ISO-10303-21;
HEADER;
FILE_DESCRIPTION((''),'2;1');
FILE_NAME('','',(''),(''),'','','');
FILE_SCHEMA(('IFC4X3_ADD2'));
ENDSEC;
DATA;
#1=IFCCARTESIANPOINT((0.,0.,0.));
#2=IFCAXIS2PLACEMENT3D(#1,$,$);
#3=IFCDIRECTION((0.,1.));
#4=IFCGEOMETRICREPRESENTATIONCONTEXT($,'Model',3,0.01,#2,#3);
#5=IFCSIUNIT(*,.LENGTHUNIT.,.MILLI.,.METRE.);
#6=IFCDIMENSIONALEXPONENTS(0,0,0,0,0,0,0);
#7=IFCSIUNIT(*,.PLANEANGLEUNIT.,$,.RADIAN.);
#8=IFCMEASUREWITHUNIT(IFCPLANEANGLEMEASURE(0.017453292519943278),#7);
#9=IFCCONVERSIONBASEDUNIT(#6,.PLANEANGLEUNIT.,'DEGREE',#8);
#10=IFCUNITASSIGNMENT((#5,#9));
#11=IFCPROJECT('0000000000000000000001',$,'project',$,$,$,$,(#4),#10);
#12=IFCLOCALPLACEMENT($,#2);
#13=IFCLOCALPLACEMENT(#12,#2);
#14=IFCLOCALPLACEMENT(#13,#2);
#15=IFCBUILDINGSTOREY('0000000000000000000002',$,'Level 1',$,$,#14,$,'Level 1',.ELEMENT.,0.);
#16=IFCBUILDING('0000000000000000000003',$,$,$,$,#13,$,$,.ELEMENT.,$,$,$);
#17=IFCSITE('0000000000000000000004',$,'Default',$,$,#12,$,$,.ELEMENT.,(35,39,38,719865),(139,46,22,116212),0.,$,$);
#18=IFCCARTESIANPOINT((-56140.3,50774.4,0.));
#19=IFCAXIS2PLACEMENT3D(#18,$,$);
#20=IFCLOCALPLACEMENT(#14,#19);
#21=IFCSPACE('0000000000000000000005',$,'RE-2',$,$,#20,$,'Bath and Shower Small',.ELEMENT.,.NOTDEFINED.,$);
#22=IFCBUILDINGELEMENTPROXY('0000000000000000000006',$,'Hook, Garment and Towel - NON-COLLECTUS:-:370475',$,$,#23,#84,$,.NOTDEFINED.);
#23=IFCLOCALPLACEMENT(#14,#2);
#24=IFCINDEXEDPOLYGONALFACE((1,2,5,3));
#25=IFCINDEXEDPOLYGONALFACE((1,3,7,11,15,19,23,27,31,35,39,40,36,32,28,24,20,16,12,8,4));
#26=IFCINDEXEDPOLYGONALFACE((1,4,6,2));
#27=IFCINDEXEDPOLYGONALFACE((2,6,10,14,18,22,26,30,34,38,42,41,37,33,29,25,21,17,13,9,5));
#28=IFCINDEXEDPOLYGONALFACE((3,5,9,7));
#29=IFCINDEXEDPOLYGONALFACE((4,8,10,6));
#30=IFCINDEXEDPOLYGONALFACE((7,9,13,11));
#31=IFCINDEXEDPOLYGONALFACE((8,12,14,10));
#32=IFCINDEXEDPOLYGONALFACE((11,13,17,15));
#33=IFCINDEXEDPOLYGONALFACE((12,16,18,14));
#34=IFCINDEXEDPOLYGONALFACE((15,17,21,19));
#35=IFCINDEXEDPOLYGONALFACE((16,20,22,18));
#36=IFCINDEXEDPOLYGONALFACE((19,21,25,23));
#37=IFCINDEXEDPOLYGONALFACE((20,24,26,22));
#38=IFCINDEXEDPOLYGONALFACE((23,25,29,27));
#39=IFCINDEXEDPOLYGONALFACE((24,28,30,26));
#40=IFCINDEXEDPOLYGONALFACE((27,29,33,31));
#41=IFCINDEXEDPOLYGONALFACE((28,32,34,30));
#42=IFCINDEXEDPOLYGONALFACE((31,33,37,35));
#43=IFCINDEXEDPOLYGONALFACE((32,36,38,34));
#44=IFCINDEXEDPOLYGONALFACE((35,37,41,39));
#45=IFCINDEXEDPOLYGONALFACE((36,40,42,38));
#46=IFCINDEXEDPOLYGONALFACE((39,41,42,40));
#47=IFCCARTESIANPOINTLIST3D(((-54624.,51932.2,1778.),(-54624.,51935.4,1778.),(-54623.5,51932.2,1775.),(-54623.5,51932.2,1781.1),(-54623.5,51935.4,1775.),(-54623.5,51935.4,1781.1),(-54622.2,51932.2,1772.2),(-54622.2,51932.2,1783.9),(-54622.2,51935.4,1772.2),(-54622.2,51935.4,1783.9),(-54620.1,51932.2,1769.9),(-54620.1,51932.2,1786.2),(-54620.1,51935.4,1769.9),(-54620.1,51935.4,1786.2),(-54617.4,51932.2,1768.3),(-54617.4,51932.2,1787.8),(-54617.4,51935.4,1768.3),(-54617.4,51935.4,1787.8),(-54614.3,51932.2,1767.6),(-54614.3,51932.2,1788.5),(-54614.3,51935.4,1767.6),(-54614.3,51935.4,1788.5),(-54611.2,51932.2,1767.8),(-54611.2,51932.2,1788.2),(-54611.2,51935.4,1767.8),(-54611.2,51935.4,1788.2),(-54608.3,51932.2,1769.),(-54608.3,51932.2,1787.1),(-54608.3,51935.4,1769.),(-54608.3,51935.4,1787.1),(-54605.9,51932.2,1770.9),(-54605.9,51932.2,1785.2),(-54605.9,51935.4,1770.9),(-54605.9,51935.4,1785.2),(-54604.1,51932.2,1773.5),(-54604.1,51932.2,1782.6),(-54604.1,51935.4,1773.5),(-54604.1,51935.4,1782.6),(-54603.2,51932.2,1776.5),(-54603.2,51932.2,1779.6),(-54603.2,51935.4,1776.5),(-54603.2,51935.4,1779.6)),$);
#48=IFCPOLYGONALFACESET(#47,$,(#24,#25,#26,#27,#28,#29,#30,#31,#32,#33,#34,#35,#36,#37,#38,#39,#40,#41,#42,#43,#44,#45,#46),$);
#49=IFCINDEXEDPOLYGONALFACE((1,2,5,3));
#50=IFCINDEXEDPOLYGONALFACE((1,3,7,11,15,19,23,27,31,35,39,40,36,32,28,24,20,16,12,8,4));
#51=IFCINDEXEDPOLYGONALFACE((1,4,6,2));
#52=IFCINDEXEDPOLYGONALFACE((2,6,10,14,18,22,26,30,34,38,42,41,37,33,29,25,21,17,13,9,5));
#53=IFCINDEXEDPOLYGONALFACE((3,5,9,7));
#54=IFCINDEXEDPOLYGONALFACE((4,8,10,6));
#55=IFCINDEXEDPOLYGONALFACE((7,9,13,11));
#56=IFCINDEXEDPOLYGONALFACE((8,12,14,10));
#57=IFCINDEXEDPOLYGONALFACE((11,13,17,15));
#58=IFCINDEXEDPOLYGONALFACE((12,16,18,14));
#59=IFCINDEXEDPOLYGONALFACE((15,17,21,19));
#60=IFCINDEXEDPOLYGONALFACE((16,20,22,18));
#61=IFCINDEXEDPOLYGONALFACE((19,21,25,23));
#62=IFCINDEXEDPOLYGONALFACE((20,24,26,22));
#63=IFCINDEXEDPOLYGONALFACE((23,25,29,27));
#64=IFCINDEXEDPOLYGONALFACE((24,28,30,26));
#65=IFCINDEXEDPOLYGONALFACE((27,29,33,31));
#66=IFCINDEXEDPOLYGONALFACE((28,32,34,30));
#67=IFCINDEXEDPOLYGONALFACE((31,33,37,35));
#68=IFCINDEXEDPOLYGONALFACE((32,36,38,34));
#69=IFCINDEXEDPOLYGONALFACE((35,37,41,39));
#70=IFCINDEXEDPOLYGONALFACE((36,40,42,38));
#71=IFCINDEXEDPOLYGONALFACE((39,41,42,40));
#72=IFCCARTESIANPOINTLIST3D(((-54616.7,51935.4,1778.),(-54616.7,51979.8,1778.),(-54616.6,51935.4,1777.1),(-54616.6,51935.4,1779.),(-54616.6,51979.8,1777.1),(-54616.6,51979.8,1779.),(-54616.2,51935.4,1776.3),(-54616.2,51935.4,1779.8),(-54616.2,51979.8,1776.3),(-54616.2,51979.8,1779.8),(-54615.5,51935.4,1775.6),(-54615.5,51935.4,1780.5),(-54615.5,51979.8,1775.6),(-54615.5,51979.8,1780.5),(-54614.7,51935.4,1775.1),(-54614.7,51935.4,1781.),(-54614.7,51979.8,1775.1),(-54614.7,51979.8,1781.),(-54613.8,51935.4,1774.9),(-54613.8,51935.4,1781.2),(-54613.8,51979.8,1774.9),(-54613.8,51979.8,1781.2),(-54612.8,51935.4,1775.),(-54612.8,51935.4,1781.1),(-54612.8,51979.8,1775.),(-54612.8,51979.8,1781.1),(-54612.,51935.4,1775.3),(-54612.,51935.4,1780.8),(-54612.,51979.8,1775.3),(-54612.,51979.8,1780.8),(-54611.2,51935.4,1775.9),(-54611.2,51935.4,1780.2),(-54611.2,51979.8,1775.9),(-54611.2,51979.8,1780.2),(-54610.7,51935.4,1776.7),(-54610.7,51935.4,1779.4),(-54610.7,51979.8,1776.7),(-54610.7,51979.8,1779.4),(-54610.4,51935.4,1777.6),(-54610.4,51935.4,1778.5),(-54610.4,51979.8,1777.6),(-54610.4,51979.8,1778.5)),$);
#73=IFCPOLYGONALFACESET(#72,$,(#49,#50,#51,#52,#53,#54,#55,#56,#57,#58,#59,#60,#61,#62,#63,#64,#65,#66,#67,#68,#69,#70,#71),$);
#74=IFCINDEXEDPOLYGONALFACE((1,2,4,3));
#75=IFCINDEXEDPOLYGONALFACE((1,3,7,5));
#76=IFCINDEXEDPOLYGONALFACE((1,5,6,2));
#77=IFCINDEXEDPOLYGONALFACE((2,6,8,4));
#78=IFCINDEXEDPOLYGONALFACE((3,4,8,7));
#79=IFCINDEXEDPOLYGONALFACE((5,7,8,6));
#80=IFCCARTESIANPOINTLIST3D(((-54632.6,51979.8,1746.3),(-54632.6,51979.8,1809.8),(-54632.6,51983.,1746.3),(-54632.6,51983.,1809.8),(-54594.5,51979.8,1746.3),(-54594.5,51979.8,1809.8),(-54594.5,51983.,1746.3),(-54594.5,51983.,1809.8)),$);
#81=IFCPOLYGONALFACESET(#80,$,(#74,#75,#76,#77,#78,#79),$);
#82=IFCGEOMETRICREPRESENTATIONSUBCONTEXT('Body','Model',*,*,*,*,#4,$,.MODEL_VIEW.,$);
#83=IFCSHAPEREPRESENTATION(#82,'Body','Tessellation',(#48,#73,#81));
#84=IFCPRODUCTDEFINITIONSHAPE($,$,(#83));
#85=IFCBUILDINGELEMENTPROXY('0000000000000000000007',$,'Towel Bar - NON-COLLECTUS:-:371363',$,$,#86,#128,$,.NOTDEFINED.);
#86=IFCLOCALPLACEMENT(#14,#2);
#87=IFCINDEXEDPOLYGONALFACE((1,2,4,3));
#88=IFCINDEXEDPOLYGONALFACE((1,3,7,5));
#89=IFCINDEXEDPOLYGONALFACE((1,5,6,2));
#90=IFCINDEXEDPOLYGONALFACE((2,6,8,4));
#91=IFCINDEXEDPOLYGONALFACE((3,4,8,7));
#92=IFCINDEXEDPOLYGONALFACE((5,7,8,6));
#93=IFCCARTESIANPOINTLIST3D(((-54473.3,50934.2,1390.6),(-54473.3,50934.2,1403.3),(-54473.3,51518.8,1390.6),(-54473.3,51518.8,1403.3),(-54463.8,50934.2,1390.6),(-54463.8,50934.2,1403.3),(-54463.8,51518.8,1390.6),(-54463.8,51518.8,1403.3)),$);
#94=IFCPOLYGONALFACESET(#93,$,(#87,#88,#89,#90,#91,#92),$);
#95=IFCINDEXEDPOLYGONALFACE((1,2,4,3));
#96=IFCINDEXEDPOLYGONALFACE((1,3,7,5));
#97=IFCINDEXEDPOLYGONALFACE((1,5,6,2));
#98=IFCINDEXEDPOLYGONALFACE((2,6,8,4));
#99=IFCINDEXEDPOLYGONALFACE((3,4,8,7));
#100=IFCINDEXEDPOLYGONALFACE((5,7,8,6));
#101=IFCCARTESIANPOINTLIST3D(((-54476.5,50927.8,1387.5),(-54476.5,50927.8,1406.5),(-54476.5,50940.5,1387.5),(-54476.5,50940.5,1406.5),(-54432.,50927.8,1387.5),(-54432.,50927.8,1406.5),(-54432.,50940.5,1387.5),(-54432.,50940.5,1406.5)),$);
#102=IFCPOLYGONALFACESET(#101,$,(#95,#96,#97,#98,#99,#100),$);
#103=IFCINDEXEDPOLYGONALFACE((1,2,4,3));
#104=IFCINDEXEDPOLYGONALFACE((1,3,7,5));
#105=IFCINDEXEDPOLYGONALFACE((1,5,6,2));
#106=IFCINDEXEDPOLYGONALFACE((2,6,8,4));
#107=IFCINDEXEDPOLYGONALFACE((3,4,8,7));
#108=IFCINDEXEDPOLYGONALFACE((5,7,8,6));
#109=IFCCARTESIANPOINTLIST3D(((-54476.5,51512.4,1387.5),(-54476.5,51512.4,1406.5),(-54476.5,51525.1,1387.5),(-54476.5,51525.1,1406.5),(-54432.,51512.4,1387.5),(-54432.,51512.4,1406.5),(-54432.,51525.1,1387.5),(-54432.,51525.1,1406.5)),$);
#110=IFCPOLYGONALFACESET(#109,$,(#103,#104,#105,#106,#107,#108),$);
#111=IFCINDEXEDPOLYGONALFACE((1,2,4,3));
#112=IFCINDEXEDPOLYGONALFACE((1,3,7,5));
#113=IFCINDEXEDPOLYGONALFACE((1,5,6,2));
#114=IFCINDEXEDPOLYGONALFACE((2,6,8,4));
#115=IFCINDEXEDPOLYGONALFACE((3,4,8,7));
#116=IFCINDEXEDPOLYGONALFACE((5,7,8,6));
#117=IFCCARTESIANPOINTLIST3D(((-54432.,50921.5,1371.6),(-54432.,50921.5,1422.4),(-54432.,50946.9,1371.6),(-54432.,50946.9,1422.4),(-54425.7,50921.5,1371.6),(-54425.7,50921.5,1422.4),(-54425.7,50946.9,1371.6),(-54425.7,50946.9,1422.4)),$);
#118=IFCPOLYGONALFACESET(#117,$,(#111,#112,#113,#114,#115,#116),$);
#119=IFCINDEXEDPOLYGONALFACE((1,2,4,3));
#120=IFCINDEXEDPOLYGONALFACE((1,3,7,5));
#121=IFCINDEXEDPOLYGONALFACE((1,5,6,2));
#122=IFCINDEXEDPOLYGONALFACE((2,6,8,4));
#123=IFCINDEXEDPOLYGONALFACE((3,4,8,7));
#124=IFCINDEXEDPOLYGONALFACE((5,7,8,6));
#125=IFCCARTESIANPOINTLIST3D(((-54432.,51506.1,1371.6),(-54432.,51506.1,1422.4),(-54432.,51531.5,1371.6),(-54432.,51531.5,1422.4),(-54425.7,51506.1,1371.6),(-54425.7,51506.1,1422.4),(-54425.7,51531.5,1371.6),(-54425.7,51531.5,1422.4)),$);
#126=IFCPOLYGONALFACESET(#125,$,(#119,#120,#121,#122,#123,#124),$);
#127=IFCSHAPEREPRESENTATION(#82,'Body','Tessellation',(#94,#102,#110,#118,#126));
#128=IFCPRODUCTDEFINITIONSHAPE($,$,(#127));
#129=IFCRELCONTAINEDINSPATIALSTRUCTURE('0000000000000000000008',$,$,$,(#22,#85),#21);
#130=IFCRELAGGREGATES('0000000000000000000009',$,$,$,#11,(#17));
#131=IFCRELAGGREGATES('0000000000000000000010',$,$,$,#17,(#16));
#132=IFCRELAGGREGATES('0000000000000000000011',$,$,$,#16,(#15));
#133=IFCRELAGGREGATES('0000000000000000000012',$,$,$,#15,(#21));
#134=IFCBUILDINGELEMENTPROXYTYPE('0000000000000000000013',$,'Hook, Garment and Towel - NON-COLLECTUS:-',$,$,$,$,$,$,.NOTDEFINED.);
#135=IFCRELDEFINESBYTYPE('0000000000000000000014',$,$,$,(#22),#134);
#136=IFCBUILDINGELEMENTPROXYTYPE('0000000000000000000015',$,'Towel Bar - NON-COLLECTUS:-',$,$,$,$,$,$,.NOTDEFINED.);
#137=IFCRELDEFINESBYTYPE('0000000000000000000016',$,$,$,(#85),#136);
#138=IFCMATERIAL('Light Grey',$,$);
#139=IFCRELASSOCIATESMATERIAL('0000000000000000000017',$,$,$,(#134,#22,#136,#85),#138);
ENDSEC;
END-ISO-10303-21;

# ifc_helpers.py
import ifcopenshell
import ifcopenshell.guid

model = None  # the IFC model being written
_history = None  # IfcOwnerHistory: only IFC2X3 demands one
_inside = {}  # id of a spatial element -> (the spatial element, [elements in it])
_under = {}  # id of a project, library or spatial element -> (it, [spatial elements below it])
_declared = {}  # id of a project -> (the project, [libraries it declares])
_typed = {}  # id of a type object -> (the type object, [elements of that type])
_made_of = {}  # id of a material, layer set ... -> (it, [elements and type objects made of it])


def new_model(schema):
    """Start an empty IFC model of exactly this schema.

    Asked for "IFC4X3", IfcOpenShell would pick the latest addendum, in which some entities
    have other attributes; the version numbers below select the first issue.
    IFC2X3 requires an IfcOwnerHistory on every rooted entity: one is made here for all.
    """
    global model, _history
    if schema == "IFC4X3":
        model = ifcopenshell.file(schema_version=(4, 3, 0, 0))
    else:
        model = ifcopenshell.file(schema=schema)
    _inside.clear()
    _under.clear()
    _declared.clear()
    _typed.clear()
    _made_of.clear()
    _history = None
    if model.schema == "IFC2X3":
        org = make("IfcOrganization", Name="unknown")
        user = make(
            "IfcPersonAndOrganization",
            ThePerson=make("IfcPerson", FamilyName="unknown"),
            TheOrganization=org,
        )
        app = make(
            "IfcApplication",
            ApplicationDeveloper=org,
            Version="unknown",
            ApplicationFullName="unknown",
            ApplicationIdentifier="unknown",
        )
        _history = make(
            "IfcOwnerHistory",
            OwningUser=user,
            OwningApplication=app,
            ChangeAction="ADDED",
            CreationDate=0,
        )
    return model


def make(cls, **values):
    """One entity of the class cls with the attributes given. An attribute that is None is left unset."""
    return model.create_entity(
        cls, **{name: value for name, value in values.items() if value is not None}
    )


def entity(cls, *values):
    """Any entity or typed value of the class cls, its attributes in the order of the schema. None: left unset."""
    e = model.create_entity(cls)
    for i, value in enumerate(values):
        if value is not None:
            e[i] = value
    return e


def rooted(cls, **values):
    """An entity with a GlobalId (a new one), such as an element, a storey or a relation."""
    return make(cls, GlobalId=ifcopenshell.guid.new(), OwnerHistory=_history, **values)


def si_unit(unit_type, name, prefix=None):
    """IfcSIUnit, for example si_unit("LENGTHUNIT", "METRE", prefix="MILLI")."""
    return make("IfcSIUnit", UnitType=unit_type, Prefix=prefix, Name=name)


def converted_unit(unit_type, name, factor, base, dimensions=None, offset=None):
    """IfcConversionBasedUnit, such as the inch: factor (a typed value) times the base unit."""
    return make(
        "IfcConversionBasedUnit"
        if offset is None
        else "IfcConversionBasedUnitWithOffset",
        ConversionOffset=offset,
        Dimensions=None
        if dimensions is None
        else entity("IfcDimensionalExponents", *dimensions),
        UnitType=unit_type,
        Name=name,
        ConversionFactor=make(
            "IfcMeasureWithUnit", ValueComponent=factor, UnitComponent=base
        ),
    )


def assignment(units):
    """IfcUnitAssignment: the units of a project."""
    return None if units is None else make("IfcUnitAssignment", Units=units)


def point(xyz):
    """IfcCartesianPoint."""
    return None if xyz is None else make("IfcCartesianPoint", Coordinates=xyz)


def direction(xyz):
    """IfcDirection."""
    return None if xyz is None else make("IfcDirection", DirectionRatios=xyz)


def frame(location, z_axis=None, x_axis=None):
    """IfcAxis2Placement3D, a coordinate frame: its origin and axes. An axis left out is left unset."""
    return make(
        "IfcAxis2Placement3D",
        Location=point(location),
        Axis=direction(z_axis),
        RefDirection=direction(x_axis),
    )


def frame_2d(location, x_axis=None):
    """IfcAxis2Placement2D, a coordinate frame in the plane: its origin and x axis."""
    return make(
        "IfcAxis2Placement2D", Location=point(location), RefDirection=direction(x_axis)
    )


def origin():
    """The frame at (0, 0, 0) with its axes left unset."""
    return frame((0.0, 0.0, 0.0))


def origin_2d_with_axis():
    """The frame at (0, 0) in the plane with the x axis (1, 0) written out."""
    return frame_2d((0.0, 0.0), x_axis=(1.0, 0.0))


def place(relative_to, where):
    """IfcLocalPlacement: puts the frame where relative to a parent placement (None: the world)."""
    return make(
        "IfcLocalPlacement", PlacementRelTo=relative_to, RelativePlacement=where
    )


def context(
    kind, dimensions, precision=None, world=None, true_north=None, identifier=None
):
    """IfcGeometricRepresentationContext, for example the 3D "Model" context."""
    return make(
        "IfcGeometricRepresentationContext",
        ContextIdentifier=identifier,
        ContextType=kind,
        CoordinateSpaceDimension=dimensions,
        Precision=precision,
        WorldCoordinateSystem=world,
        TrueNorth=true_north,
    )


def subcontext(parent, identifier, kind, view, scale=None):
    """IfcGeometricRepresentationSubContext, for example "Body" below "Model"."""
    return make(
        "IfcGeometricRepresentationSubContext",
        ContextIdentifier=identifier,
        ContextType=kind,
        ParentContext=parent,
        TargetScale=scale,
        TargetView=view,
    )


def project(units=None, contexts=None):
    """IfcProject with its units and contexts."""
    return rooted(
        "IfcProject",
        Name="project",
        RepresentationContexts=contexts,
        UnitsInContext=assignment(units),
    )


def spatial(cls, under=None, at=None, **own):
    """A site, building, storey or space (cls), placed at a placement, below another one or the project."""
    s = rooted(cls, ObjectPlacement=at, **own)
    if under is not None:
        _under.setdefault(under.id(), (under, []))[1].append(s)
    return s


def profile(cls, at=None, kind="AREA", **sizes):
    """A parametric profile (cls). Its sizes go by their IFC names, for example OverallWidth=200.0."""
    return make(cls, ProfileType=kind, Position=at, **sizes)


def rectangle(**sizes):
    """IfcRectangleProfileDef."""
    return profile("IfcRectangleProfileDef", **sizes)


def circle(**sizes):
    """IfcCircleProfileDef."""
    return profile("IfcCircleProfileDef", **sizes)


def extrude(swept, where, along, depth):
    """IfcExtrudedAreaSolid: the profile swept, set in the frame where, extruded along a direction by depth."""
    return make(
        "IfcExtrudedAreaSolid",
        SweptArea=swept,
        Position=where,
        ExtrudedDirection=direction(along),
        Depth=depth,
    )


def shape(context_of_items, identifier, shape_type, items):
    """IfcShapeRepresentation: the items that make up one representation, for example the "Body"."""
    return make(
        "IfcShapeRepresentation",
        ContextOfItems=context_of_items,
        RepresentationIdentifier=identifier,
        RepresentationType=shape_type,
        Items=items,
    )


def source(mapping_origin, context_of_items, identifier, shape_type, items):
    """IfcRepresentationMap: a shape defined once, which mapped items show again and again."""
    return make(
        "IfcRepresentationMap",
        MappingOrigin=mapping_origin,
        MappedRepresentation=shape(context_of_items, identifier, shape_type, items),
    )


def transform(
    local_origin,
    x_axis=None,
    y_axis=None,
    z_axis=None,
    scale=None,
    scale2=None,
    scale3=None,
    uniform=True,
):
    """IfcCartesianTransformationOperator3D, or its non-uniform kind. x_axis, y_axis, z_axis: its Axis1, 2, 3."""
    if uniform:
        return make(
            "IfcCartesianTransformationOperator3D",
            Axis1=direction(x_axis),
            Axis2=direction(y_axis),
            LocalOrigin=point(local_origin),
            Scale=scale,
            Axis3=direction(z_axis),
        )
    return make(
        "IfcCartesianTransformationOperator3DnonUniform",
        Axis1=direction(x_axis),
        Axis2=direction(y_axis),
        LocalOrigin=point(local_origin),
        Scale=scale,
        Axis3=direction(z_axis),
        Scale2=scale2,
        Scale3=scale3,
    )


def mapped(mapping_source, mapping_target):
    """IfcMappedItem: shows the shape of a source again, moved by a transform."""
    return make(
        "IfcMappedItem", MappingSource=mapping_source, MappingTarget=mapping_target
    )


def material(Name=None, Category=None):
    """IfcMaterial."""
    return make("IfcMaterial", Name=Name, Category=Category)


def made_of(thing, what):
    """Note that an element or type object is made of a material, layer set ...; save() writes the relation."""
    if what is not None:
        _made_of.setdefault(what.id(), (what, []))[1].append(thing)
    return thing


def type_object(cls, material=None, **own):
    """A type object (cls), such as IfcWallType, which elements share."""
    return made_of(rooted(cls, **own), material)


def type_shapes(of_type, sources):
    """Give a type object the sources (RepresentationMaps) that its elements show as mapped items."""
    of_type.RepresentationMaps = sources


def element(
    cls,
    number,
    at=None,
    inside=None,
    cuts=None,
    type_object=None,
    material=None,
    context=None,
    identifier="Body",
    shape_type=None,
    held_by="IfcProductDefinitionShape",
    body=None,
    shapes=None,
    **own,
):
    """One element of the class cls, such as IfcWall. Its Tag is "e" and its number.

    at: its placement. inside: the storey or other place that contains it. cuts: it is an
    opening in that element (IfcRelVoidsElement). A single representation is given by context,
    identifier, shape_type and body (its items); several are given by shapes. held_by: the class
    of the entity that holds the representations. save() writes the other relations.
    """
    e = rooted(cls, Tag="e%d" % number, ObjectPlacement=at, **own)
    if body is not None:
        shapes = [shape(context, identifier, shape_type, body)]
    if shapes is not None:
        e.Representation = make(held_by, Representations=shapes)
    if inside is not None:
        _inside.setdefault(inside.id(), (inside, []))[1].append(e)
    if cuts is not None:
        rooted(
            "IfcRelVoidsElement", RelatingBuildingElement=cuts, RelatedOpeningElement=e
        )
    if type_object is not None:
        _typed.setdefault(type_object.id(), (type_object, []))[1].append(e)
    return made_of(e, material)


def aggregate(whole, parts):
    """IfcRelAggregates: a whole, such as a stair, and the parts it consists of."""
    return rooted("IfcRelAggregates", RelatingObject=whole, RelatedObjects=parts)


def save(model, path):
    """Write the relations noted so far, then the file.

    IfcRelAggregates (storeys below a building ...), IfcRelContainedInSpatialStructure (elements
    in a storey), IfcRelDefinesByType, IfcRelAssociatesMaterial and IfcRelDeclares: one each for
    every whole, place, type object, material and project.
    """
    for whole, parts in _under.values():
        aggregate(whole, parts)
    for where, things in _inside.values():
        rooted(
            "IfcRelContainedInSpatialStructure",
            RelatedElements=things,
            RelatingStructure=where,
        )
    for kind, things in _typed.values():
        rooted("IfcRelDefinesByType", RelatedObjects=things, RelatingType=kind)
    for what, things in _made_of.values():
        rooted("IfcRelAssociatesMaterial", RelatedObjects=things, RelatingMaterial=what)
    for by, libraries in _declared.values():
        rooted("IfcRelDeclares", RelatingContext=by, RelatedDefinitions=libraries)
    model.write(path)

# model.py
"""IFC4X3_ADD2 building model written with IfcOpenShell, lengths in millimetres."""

from ifc_helpers import new_model, entity, si_unit, converted_unit, direction, frame, frame_2d, origin, origin_2d_with_axis, place, context, subcontext, project, spatial, rectangle, circle, extrude, source, transform, mapped, material, type_object, type_shapes, element, save


model = new_model("IFC4X3_ADD2")

# Units and contexts
model_context = context("Model", 3, precision=0.01, world=origin(), true_north=direction((0.0, 1.0)))
body_context = subcontext(model_context, "Body", "Model", "MODEL_VIEW")
ifc_project = project(units=[si_unit("LENGTHUNIT", "METRE", prefix="MILLI"), converted_unit("PLANEANGLEUNIT", "DEGREE", entity("IfcPlaneAngleMeasure", 0.017453292519943278), si_unit("PLANEANGLEUNIT", "RADIAN"), dimensions=[0, 0, 0, 0, 0, 0, 0])], contexts=[model_context])

# Site, building, storey
site_placement = place(None, origin())
site = spatial("IfcSite", under=ifc_project, at=site_placement, Name="Default", CompositionType="ELEMENT", RefLatitude=(35, 39, 38, 719865), RefLongitude=(139, 46, 22, 116212), RefElevation=0.0)
building_placement = place(site_placement, origin())
building = spatial("IfcBuilding", under=site, at=building_placement, CompositionType="ELEMENT")
storey_placement = place(building_placement, origin())
storey = spatial("IfcBuildingStorey", under=building, at=storey_placement, Name="Level 1", LongName="Level 1", CompositionType="ELEMENT", Elevation=0.0)

# Shared definitions
ifc_material_1 = material(Name="Light Grey")

# Shared definitions
space_1_placement = place(storey_placement, frame((-56140.3, 50774.4, 0.0)))
space_1 = spatial("IfcSpace", under=storey, at=space_1_placement, Name="RE-2", LongName="Bath and Shower Small", CompositionType="ELEMENT", PredefinedType="NOTDEFINED")

# Building element proxies
building_element_proxy_type_1 = type_object("IfcBuildingElementProxyType", Name="Hook, Garment and Towel - NON-COLLECTUS:-", PredefinedType="NOTDEFINED", material=ifc_material_1)
shared_shape_1 = source(origin(), body_context, "Body", "SweptSolid", [
    extrude(circle(Radius=10.5, at=frame_2d((0.0, 0.0), x_axis=(1.0, 0.0))), frame((19.1, -50.8, 31.8), z_axis=(0.0, 1.0, 0.0), x_axis=(-1.0, 0.0, 0.0)), (0.0, 0.0, 1.0), 3.2),
    extrude(circle(Radius=3.2, at=frame_2d((0.0, 0.0), x_axis=(1.0, 0.0))), frame((19.1, -47.6, 31.8), z_axis=(0.0, 1.0, 0.0), x_axis=(-1.0, 0.0, 0.0)), (0.0, 0.0, 1.0), 44.5),
    extrude(rectangle(XDim=3.2, YDim=38.1, at=origin_2d_with_axis()), frame((19.1, -1.6, 0.0), z_axis=(0.0, 0.0, 1.0), x_axis=(0.0, 1.0, 0.0)), (0.0, 0.0, 1.0), 63.5),
])
type_shapes(building_element_proxy_type_1, [shared_shape_1])
proxy_1_placement = place(space_1_placement, frame((1507.7, 1208.6, 1746.3)))
element("IfcBuildingElementProxy", 1, at=proxy_1_placement, inside=space_1, type_object=building_element_proxy_type_1, material=ifc_material_1, Name="Hook, Garment and Towel - NON-COLLECTUS:-:370475", PredefinedType="NOTDEFINED", context=body_context, shape_type="MappedRepresentation", body=[
    mapped(shared_shape_1, transform((0.0, 0.0, 0.0), scale=1.0)),
])
building_element_proxy_type_2 = type_object("IfcBuildingElementProxyType", Name="Towel Bar - NON-COLLECTUS:-", PredefinedType="NOTDEFINED", material=ifc_material_1)
shared_shape_2 = source(origin(), body_context, "Body", "SweptSolid", [
    extrude(rectangle(XDim=584.6, YDim=9.5, at=origin_2d_with_axis()), frame((0.0, -42.9, 19.1), z_axis=(0.0, 0.0, 1.0), x_axis=(-1.0, 0.0, 0.0)), (0.0, 0.0, 1.0), 12.7),
    extrude(rectangle(XDim=44.5, YDim=12.7, at=frame_2d((0.0, 0.0), x_axis=(1.0, 0.0))), frame((292.3, -28.6, 15.9), z_axis=(0.0, 0.0, 1.0), x_axis=(0.0, -1.0, 0.0)), (0.0, 0.0, 1.0), 19.1),
    extrude(rectangle(XDim=44.5, YDim=12.7, at=origin_2d_with_axis()), frame((-292.3, -28.6, 15.9), z_axis=(0.0, 0.0, 1.0), x_axis=(0.0, -1.0, 0.0)), (0.0, 0.0, 1.0), 19.1),
    extrude(rectangle(XDim=6.3, YDim=25.4, at=frame_2d((0.0, 0.0), x_axis=(1.0, 0.0))), frame((292.3, -3.2, 0.0), z_axis=(0.0, 0.0, 1.0), x_axis=(0.0, -1.0, 0.0)), (0.0, 0.0, 1.0), 50.8),
    extrude(rectangle(XDim=6.3, YDim=25.4, at=frame_2d((0.0, 0.0), x_axis=(1.0, 0.0))), frame((-292.3, -3.2, 0.0), z_axis=(0.0, 0.0, 1.0), x_axis=(0.0, -1.0, 0.0)), (0.0, 0.0, 1.0), 50.8),
])
type_shapes(building_element_proxy_type_2, [shared_shape_2])
proxy_2_placement = place(space_1_placement, frame((1714.6, 452.0, 1371.6), z_axis=(0.0, 0.0, 1.0), x_axis=(0.000001, -1.0, 0.0)))
element("IfcBuildingElementProxy", 2, at=proxy_2_placement, inside=space_1, type_object=building_element_proxy_type_2, material=ifc_material_1, Name="Towel Bar - NON-COLLECTUS:-:371363", PredefinedType="NOTDEFINED", context=body_context, shape_type="MappedRepresentation", body=[
    mapped(shared_shape_2, transform((0.0, 0.0, 0.0), scale=1.0)),
])

save(model, "model.ifc")
